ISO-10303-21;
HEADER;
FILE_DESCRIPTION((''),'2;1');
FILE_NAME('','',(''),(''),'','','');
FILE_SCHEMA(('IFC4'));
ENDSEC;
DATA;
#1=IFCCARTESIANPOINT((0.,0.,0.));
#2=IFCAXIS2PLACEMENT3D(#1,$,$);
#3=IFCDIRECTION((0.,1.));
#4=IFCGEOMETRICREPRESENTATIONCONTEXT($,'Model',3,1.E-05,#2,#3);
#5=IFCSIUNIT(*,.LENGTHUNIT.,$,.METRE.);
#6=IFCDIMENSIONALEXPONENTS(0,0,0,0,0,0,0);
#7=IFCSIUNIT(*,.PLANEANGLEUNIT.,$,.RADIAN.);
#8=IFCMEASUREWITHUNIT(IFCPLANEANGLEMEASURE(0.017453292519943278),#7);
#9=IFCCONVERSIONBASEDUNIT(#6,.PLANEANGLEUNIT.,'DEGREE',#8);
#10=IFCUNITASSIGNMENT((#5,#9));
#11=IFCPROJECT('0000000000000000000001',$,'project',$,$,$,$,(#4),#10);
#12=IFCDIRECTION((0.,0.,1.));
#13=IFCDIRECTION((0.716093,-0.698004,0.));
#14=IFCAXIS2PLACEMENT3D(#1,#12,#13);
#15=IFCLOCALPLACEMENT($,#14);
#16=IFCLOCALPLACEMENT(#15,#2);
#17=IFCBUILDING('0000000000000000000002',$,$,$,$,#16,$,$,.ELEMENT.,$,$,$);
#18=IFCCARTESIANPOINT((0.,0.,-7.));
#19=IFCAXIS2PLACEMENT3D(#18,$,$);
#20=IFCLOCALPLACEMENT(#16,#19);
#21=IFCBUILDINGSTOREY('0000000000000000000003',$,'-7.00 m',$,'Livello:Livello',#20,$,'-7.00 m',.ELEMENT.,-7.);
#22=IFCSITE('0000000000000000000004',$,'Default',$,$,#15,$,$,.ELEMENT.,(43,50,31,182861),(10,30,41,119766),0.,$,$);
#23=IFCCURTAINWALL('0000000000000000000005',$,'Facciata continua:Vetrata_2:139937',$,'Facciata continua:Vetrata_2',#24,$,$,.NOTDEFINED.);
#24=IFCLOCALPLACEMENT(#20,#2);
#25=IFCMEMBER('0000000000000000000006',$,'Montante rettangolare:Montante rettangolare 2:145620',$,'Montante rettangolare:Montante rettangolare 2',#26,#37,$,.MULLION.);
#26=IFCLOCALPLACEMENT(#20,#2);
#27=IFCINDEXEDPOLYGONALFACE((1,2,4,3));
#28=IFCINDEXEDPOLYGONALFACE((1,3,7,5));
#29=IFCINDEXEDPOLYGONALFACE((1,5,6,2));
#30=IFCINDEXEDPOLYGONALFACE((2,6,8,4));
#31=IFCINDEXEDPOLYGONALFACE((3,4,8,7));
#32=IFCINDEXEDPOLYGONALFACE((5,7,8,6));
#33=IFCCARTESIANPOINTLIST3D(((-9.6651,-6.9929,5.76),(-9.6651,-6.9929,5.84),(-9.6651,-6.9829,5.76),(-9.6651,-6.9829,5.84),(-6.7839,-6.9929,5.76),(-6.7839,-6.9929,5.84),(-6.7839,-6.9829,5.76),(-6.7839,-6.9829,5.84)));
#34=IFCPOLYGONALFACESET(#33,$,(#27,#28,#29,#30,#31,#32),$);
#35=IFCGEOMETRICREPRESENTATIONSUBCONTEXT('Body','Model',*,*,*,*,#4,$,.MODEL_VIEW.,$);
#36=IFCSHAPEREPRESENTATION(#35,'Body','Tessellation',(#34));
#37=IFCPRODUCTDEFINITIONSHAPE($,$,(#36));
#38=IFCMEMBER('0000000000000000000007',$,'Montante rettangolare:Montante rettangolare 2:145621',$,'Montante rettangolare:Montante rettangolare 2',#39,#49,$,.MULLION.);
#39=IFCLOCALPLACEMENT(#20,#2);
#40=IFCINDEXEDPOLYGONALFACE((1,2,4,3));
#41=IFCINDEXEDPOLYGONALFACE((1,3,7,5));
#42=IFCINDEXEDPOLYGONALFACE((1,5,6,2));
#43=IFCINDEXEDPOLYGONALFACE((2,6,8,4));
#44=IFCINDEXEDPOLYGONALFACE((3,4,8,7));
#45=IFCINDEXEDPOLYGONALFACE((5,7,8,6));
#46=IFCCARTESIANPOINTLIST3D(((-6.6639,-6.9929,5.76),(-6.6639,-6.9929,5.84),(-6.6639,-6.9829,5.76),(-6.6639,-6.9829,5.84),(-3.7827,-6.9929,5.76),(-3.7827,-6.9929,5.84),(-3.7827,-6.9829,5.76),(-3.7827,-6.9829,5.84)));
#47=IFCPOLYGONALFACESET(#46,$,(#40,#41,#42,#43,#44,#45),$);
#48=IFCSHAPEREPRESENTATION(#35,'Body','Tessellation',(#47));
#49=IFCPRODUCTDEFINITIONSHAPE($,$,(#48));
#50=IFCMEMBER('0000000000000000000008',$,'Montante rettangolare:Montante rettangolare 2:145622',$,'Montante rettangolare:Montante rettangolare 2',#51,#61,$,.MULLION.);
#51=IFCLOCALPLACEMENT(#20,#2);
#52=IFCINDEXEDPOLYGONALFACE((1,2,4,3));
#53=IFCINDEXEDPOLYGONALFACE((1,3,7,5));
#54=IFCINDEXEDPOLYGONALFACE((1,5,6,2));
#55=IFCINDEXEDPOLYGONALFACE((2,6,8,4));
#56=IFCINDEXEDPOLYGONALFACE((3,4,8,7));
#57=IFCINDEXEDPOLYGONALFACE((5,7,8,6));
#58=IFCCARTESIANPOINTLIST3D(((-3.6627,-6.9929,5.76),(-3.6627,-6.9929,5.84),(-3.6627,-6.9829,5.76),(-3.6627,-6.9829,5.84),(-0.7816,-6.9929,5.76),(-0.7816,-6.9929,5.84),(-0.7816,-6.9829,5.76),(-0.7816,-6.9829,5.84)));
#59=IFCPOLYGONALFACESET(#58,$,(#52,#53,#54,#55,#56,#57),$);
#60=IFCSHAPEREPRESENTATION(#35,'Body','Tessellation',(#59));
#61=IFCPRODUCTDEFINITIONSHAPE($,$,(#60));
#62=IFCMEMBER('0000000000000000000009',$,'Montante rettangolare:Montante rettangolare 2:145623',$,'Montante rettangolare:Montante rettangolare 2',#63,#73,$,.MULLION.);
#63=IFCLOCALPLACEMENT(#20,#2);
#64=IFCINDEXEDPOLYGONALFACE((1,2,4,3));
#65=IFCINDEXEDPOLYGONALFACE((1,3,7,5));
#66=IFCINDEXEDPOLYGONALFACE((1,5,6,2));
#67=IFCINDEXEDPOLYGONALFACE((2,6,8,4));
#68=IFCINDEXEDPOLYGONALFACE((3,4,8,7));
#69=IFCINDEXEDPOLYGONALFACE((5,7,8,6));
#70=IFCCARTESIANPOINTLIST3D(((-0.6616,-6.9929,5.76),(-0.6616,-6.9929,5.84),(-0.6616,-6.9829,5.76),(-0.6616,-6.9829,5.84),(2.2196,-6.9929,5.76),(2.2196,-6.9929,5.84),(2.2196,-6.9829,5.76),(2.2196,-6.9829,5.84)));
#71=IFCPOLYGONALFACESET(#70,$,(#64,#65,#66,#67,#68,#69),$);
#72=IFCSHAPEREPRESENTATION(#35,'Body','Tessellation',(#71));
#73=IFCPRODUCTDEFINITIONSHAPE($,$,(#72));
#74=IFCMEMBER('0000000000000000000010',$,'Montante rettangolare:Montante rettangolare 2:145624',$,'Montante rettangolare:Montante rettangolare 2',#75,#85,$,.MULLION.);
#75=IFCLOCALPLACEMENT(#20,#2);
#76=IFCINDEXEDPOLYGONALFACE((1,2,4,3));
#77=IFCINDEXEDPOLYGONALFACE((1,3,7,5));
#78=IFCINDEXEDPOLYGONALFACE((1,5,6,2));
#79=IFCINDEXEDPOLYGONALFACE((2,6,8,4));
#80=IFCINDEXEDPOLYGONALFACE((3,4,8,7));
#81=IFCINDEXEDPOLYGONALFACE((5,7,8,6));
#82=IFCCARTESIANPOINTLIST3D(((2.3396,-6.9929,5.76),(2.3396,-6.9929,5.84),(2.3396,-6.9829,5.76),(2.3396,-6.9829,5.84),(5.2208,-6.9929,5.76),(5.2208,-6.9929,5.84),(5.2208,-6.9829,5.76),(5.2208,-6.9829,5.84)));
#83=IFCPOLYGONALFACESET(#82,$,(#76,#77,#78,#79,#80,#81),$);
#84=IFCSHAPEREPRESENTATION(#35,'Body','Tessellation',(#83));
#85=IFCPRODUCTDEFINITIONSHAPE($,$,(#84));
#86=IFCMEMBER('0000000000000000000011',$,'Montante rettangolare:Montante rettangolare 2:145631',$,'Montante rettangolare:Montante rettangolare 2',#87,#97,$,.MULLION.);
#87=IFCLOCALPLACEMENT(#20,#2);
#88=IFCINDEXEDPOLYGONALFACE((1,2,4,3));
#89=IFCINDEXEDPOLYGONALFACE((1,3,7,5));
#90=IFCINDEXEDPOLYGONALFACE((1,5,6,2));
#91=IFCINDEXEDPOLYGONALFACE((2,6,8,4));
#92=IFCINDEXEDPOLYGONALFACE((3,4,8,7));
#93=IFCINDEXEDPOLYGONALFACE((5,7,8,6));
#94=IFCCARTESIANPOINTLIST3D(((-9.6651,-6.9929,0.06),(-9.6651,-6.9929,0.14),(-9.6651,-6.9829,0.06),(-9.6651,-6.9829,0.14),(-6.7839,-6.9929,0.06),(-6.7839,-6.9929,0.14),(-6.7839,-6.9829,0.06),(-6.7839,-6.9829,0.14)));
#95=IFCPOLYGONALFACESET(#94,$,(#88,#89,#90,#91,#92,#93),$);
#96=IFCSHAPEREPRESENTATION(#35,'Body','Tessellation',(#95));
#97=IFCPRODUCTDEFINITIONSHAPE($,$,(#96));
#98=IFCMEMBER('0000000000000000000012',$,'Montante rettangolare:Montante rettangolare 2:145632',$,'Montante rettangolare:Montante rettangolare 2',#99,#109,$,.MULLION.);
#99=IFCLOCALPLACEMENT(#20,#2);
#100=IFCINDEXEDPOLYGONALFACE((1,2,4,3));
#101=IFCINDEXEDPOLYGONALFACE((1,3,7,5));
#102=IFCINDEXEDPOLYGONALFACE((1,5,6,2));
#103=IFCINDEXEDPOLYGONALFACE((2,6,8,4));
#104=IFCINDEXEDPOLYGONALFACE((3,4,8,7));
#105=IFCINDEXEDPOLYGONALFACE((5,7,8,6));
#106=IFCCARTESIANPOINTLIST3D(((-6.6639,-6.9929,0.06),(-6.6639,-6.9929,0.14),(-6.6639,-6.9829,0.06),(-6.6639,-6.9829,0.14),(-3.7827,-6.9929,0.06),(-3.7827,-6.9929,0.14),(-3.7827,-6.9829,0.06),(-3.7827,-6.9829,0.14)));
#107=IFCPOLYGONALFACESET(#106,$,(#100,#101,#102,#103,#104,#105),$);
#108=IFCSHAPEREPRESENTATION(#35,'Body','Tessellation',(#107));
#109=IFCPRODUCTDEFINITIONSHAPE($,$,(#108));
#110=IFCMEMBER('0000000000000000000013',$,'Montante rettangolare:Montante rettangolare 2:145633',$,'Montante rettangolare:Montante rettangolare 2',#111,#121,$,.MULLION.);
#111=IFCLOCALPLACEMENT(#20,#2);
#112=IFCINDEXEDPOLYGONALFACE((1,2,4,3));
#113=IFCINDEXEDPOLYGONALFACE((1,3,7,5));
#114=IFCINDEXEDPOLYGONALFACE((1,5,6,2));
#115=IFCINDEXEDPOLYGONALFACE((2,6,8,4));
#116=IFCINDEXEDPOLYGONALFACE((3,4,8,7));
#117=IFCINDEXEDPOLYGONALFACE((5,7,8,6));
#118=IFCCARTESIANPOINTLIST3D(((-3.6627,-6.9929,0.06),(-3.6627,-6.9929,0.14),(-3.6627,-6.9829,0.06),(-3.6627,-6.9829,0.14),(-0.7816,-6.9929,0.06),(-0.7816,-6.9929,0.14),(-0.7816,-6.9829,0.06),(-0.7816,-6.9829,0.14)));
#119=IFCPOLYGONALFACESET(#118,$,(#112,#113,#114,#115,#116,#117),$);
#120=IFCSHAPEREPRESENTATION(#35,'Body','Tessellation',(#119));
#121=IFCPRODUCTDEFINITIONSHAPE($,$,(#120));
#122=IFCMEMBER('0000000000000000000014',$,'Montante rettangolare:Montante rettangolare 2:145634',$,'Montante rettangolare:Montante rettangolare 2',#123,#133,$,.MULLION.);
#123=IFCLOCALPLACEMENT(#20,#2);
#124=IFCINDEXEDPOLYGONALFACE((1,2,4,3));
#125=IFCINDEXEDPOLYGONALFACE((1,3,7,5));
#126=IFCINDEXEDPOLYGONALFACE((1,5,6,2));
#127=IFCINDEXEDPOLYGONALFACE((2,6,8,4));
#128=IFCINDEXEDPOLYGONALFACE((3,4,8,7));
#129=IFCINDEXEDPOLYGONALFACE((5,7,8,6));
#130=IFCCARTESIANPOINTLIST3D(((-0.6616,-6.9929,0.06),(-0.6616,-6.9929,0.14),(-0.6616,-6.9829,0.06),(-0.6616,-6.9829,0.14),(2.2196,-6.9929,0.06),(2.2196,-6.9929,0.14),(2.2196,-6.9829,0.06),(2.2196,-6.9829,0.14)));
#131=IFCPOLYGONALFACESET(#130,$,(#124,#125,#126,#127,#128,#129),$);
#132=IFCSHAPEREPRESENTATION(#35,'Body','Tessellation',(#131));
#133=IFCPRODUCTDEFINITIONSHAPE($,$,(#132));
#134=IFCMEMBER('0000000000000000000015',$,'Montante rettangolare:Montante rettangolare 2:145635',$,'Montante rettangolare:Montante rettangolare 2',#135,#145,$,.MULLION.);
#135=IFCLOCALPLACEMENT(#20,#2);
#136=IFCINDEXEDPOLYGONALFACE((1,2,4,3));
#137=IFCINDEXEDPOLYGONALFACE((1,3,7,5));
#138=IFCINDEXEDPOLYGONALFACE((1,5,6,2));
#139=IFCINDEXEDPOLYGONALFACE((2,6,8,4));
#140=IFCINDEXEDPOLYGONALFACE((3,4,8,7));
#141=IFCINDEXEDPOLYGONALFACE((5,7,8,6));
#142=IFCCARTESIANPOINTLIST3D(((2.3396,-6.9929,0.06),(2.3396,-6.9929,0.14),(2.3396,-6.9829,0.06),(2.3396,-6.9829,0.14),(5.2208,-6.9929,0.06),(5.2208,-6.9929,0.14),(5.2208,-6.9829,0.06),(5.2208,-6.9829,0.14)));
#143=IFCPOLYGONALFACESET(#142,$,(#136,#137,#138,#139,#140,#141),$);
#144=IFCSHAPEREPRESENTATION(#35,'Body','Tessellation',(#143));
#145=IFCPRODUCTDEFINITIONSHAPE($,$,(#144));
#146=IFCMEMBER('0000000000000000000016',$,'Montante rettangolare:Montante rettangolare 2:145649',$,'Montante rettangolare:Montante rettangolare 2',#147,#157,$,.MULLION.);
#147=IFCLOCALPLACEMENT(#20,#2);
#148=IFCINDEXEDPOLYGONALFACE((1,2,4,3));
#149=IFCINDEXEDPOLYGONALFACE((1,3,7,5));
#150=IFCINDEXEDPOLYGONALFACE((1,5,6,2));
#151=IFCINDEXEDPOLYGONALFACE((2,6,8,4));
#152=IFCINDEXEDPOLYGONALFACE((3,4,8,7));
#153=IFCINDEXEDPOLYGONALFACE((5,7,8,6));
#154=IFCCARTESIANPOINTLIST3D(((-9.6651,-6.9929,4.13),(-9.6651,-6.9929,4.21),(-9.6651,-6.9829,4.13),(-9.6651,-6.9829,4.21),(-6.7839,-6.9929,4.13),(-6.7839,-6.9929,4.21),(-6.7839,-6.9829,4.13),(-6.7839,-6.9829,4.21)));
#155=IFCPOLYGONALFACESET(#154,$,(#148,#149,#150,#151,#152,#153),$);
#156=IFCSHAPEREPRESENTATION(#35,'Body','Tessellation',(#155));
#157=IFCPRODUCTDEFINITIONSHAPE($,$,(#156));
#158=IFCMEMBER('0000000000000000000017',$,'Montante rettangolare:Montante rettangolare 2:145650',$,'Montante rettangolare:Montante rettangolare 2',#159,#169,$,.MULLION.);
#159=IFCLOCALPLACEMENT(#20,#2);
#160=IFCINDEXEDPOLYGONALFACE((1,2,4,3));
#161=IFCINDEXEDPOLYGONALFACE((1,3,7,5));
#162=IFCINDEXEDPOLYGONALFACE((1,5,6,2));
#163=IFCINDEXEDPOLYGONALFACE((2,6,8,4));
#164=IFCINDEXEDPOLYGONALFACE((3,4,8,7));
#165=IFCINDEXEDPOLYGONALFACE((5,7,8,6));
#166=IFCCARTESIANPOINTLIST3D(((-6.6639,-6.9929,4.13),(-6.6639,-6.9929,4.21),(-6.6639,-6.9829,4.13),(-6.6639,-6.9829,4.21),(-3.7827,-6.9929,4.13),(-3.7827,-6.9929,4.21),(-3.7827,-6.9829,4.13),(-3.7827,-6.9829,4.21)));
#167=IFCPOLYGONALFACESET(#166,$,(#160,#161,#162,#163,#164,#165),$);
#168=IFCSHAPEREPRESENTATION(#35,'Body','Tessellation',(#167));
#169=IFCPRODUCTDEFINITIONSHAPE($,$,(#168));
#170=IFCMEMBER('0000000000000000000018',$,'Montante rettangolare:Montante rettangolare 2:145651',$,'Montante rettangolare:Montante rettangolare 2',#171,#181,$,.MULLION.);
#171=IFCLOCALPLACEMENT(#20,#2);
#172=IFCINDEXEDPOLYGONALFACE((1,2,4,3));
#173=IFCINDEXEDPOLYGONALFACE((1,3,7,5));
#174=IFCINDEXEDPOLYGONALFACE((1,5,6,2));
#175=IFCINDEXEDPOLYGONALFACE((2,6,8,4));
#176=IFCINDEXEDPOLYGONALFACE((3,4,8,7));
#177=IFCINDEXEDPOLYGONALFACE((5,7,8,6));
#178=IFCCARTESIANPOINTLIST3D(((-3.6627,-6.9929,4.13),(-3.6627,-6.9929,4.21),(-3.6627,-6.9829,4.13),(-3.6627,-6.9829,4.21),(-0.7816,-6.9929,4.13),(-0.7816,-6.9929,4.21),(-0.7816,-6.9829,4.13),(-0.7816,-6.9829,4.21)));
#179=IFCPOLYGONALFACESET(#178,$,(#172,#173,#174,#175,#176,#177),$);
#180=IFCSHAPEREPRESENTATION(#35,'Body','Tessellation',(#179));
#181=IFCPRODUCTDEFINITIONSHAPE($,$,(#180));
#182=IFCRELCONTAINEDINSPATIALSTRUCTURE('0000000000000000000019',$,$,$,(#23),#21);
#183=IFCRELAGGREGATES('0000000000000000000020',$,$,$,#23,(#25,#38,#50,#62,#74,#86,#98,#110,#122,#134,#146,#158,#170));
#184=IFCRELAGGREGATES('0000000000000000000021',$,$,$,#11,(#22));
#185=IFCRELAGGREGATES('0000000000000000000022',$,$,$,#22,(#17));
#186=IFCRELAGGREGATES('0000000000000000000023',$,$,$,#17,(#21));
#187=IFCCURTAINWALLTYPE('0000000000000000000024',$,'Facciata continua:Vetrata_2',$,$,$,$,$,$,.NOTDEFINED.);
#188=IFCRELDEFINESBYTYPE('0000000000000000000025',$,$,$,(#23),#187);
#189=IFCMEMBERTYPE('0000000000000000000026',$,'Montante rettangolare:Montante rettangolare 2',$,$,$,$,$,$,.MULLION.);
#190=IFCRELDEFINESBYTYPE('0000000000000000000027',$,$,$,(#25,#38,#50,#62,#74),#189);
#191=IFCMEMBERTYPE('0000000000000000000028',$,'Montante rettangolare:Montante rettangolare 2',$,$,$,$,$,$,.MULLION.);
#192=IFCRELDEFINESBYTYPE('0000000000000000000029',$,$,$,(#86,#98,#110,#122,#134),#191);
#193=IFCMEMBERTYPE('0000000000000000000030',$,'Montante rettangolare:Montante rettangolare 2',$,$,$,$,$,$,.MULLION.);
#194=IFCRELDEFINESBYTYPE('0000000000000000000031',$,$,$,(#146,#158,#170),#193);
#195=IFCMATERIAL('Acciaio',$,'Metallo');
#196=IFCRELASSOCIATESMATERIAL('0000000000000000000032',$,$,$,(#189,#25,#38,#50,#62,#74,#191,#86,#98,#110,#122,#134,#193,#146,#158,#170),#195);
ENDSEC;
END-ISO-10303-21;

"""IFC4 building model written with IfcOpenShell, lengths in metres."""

from ifc_helpers import new_model, entity, si_unit, converted_unit, direction, frame, origin, place, context, subcontext, project, spatial, indexed_curve, outline, extrude, source, transform, mapped, material, type_object, type_shapes, element, aggregate, save


model = new_model("IFC4")

# Units and contexts
model_context = context("Model", 3, precision=1e-05, world=origin(), true_north=direction((0.0, 1.0)))
body_context = subcontext(model_context, "Body", "Model", "MODEL_VIEW")
ifc_project = project(units=[si_unit("LENGTHUNIT", "METRE"), converted_unit("PLANEANGLEUNIT", "DEGREE", entity("IfcPlaneAngleMeasure", 0.017453292519943278), si_unit("PLANEANGLEUNIT", "RADIAN"), dimensions=[0, 0, 0, 0, 0, 0, 0])], contexts=[model_context])

# Site, building, storey
site_placement = place(None, frame((0.0, 0.0, 0.0), z_axis=(0.0, 0.0, 1.0), x_axis=(0.716093, -0.698004, 0.0)))
site = spatial("IfcSite", under=ifc_project, at=site_placement, Name="Default", CompositionType="ELEMENT", RefLatitude=(43, 50, 31, 182861), RefLongitude=(10, 30, 41, 119766), RefElevation=0.0)
building_placement = place(site_placement, origin())
building = spatial("IfcBuilding", under=site, at=building_placement, CompositionType="ELEMENT")
storey_placement = place(building_placement, frame((0.0, 0.0, -7.0)))
storey = spatial("IfcBuildingStorey", under=building, at=storey_placement, Name="-7.00 m", ObjectType="Livello:Livello", LongName="-7.00 m", CompositionType="ELEMENT", Elevation=-7.0)

# Curtain wall, members
curtain_wall_type = type_object("IfcCurtainWallType", Name="Facciata continua:Vetrata_2", PredefinedType="NOTDEFINED")
curtain_wall_placement = place(storey_placement, frame((0.0, 0.0, 7.0)))
curtain_wall = element("IfcCurtainWall", 1, at=curtain_wall_placement, inside=storey, type_object=curtain_wall_type, Name="Facciata continua:Vetrata_2:139937", ObjectType="Facciata continua:Vetrata_2", PredefinedType="NOTDEFINED")
ifc_material = material(Name="Acciaio", Category="Metallo")
member_type_1 = type_object("IfcMemberType", Name="Montante rettangolare:Montante rettangolare 2", PredefinedType="MULLION", material=ifc_material)
shared_shape_1 = source(origin(), body_context, "Body", "SweptSolid", [
    extrude(outline(indexed_curve([(-0.04, -0.005), (0.04, -0.005), (0.04, 0.005), (-0.04, 0.005), (-0.04, -0.005)], self_intersect=False)), frame((-0.04, 0.01, -2.8812), z_axis=(0.0, 0.0, 1.0), x_axis=(-1.0, 0.0, 0.0)), (0.0, 0.0, 1.0), 2.8812),
])
type_shapes(member_type_1, [shared_shape_1])
member_1_placement = place(curtain_wall_placement, frame((-6.7839, -6.9779, -1.16), z_axis=(1.0, 0.0, 0.0), x_axis=(0.0, 0.0, 1.0)))
member_1 = element("IfcMember", 2, at=member_1_placement, type_object=member_type_1, material=ifc_material, Name="Montante rettangolare:Montante rettangolare 2:145620", ObjectType="Montante rettangolare:Montante rettangolare 2", PredefinedType="MULLION", context=body_context, shape_type="MappedRepresentation", body=[
    mapped(shared_shape_1, transform((0.0, 0.0, 0.0), scale=1.0)),
])
member_2_placement = place(curtain_wall_placement, frame((-3.7827, -6.9779, -1.16), z_axis=(1.0, 0.0, 0.0), x_axis=(0.0, 0.0, 1.0)))
member_2 = element("IfcMember", 3, at=member_2_placement, type_object=member_type_1, material=ifc_material, Name="Montante rettangolare:Montante rettangolare 2:145621", ObjectType="Montante rettangolare:Montante rettangolare 2", PredefinedType="MULLION", context=body_context, shape_type="MappedRepresentation", body=[
    mapped(shared_shape_1, transform((0.0, 0.0, 0.0), scale=1.0)),
])
member_3_placement = place(curtain_wall_placement, frame((-0.7816, -6.9779, -1.16), z_axis=(1.0, 0.0, 0.0), x_axis=(0.0, 0.0, 1.0)))
member_3 = element("IfcMember", 4, at=member_3_placement, type_object=member_type_1, material=ifc_material, Name="Montante rettangolare:Montante rettangolare 2:145622", ObjectType="Montante rettangolare:Montante rettangolare 2", PredefinedType="MULLION", context=body_context, shape_type="MappedRepresentation", body=[
    mapped(shared_shape_1, transform((0.0, 0.0, 0.0), scale=1.0)),
])
member_4_placement = place(curtain_wall_placement, frame((2.2196, -6.9779, -1.16), z_axis=(1.0, 0.0, 0.0), x_axis=(0.0, 0.0, 1.0)))
member_4 = element("IfcMember", 5, at=member_4_placement, type_object=member_type_1, material=ifc_material, Name="Montante rettangolare:Montante rettangolare 2:145623", ObjectType="Montante rettangolare:Montante rettangolare 2", PredefinedType="MULLION", context=body_context, shape_type="MappedRepresentation", body=[
    mapped(shared_shape_1, transform((0.0, 0.0, 0.0), scale=1.0)),
])
member_5_placement = place(curtain_wall_placement, frame((5.2208, -6.9779, -1.16), z_axis=(1.0, 0.0, 0.0), x_axis=(0.0, 0.0, 1.0)))
member_5 = element("IfcMember", 6, at=member_5_placement, type_object=member_type_1, material=ifc_material, Name="Montante rettangolare:Montante rettangolare 2:145624", ObjectType="Montante rettangolare:Montante rettangolare 2", PredefinedType="MULLION", context=body_context, shape_type="MappedRepresentation", body=[
    mapped(shared_shape_1, transform((0.0, 0.0, 0.0), scale=1.0)),
])
member_type_2 = type_object("IfcMemberType", Name="Montante rettangolare:Montante rettangolare 2", PredefinedType="MULLION", material=ifc_material)
shared_shape_2 = source(origin(), body_context, "Body", "SweptSolid", [
    extrude(outline(indexed_curve([(-0.04, -0.005), (0.04, -0.005), (0.04, 0.005), (-0.04, 0.005), (-0.04, -0.005)], self_intersect=False)), frame((-0.04, 0.01, -2.8812), z_axis=(0.0, 0.0, 1.0), x_axis=(-1.0, 0.0, 0.0)), (0.0, 0.0, 1.0), 2.8812),
])
type_shapes(member_type_2, [shared_shape_2])
member_6_placement = place(curtain_wall_placement, frame((-9.6651, -6.9779, -6.94), z_axis=(-1.0, 0.0, 0.0), x_axis=(0.0, 0.0, -1.0)))
member_6 = element("IfcMember", 7, at=member_6_placement, type_object=member_type_2, material=ifc_material, Name="Montante rettangolare:Montante rettangolare 2:145631", ObjectType="Montante rettangolare:Montante rettangolare 2", PredefinedType="MULLION", context=body_context, shape_type="MappedRepresentation", body=[
    mapped(shared_shape_2, transform((0.0, 0.0, 0.0), scale=1.0)),
])
member_7_placement = place(curtain_wall_placement, frame((-6.6639, -6.9779, -6.94), z_axis=(-1.0, 0.0, 0.0), x_axis=(0.0, 0.0, -1.0)))
member_7 = element("IfcMember", 8, at=member_7_placement, type_object=member_type_2, material=ifc_material, Name="Montante rettangolare:Montante rettangolare 2:145632", ObjectType="Montante rettangolare:Montante rettangolare 2", PredefinedType="MULLION", context=body_context, shape_type="MappedRepresentation", body=[
    mapped(shared_shape_2, transform((0.0, 0.0, 0.0), scale=1.0)),
])
member_8_placement = place(curtain_wall_placement, frame((-3.6627, -6.9779, -6.94), z_axis=(-1.0, 0.0, 0.0), x_axis=(0.0, 0.0, -1.0)))
member_8 = element("IfcMember", 9, at=member_8_placement, type_object=member_type_2, material=ifc_material, Name="Montante rettangolare:Montante rettangolare 2:145633", ObjectType="Montante rettangolare:Montante rettangolare 2", PredefinedType="MULLION", context=body_context, shape_type="MappedRepresentation", body=[
    mapped(shared_shape_2, transform((0.0, 0.0, 0.0), scale=1.0)),
])
member_9_placement = place(curtain_wall_placement, frame((-0.6616, -6.9779, -6.94), z_axis=(-1.0, 0.0, 0.0), x_axis=(0.0, 0.0, -1.0)))
member_9 = element("IfcMember", 10, at=member_9_placement, type_object=member_type_2, material=ifc_material, Name="Montante rettangolare:Montante rettangolare 2:145634", ObjectType="Montante rettangolare:Montante rettangolare 2", PredefinedType="MULLION", context=body_context, shape_type="MappedRepresentation", body=[
    mapped(shared_shape_2, transform((0.0, 0.0, 0.0), scale=1.0)),
])
member_10_placement = place(curtain_wall_placement, frame((2.3396, -6.9779, -6.94), z_axis=(-1.0, 0.0, 0.0), x_axis=(0.0, 0.0, -1.0)))
member_10 = element("IfcMember", 11, at=member_10_placement, type_object=member_type_2, material=ifc_material, Name="Montante rettangolare:Montante rettangolare 2:145635", ObjectType="Montante rettangolare:Montante rettangolare 2", PredefinedType="MULLION", context=body_context, shape_type="MappedRepresentation", body=[
    mapped(shared_shape_2, transform((0.0, 0.0, 0.0), scale=1.0)),
])
member_type_3 = type_object("IfcMemberType", Name="Montante rettangolare:Montante rettangolare 2", PredefinedType="MULLION", material=ifc_material)
shared_shape_3 = source(origin(), body_context, "Body", "SweptSolid", [
    extrude(outline(indexed_curve([(-0.04, -0.005), (0.04, -0.005), (0.04, 0.005), (-0.04, 0.005), (-0.04, -0.005)], self_intersect=False)), frame((0.0, 0.01, -2.8812), z_axis=(0.0, 0.0, 1.0), x_axis=(-1.0, 0.0, 0.0)), (0.0, 0.0, 1.0), 2.8812),
])
type_shapes(member_type_3, [shared_shape_3])
member_11_placement = place(curtain_wall_placement, frame((-6.7839, -6.9779, -2.83), z_axis=(1.0, 0.0, 0.0), x_axis=(0.0, 0.0, 1.0)))
member_11 = element("IfcMember", 12, at=member_11_placement, type_object=member_type_3, material=ifc_material, Name="Montante rettangolare:Montante rettangolare 2:145649", ObjectType="Montante rettangolare:Montante rettangolare 2", PredefinedType="MULLION", context=body_context, shape_type="MappedRepresentation", body=[
    mapped(shared_shape_3, transform((0.0, 0.0, 0.0), scale=1.0)),
])
member_12_placement = place(curtain_wall_placement, frame((-3.7827, -6.9779, -2.83), z_axis=(1.0, 0.0, 0.0), x_axis=(0.0, 0.0, 1.0)))
member_12 = element("IfcMember", 13, at=member_12_placement, type_object=member_type_3, material=ifc_material, Name="Montante rettangolare:Montante rettangolare 2:145650", ObjectType="Montante rettangolare:Montante rettangolare 2", PredefinedType="MULLION", context=body_context, shape_type="MappedRepresentation", body=[
    mapped(shared_shape_3, transform((0.0, 0.0, 0.0), scale=1.0)),
])
member_13_placement = place(curtain_wall_placement, frame((-0.7816, -6.9779, -2.83), z_axis=(1.0, 0.0, 0.0), x_axis=(0.0, 0.0, 1.0)))
member_13 = element("IfcMember", 14, at=member_13_placement, type_object=member_type_3, material=ifc_material, Name="Montante rettangolare:Montante rettangolare 2:145651", ObjectType="Montante rettangolare:Montante rettangolare 2", PredefinedType="MULLION", context=body_context, shape_type="MappedRepresentation", body=[
    mapped(shared_shape_3, transform((0.0, 0.0, 0.0), scale=1.0)),
])
aggregate(curtain_wall, [member_1, member_2, member_3, member_4, member_5, member_6, member_7, member_8, member_9, member_10, member_11, member_12, member_13])

save(model, "model.ifc")
